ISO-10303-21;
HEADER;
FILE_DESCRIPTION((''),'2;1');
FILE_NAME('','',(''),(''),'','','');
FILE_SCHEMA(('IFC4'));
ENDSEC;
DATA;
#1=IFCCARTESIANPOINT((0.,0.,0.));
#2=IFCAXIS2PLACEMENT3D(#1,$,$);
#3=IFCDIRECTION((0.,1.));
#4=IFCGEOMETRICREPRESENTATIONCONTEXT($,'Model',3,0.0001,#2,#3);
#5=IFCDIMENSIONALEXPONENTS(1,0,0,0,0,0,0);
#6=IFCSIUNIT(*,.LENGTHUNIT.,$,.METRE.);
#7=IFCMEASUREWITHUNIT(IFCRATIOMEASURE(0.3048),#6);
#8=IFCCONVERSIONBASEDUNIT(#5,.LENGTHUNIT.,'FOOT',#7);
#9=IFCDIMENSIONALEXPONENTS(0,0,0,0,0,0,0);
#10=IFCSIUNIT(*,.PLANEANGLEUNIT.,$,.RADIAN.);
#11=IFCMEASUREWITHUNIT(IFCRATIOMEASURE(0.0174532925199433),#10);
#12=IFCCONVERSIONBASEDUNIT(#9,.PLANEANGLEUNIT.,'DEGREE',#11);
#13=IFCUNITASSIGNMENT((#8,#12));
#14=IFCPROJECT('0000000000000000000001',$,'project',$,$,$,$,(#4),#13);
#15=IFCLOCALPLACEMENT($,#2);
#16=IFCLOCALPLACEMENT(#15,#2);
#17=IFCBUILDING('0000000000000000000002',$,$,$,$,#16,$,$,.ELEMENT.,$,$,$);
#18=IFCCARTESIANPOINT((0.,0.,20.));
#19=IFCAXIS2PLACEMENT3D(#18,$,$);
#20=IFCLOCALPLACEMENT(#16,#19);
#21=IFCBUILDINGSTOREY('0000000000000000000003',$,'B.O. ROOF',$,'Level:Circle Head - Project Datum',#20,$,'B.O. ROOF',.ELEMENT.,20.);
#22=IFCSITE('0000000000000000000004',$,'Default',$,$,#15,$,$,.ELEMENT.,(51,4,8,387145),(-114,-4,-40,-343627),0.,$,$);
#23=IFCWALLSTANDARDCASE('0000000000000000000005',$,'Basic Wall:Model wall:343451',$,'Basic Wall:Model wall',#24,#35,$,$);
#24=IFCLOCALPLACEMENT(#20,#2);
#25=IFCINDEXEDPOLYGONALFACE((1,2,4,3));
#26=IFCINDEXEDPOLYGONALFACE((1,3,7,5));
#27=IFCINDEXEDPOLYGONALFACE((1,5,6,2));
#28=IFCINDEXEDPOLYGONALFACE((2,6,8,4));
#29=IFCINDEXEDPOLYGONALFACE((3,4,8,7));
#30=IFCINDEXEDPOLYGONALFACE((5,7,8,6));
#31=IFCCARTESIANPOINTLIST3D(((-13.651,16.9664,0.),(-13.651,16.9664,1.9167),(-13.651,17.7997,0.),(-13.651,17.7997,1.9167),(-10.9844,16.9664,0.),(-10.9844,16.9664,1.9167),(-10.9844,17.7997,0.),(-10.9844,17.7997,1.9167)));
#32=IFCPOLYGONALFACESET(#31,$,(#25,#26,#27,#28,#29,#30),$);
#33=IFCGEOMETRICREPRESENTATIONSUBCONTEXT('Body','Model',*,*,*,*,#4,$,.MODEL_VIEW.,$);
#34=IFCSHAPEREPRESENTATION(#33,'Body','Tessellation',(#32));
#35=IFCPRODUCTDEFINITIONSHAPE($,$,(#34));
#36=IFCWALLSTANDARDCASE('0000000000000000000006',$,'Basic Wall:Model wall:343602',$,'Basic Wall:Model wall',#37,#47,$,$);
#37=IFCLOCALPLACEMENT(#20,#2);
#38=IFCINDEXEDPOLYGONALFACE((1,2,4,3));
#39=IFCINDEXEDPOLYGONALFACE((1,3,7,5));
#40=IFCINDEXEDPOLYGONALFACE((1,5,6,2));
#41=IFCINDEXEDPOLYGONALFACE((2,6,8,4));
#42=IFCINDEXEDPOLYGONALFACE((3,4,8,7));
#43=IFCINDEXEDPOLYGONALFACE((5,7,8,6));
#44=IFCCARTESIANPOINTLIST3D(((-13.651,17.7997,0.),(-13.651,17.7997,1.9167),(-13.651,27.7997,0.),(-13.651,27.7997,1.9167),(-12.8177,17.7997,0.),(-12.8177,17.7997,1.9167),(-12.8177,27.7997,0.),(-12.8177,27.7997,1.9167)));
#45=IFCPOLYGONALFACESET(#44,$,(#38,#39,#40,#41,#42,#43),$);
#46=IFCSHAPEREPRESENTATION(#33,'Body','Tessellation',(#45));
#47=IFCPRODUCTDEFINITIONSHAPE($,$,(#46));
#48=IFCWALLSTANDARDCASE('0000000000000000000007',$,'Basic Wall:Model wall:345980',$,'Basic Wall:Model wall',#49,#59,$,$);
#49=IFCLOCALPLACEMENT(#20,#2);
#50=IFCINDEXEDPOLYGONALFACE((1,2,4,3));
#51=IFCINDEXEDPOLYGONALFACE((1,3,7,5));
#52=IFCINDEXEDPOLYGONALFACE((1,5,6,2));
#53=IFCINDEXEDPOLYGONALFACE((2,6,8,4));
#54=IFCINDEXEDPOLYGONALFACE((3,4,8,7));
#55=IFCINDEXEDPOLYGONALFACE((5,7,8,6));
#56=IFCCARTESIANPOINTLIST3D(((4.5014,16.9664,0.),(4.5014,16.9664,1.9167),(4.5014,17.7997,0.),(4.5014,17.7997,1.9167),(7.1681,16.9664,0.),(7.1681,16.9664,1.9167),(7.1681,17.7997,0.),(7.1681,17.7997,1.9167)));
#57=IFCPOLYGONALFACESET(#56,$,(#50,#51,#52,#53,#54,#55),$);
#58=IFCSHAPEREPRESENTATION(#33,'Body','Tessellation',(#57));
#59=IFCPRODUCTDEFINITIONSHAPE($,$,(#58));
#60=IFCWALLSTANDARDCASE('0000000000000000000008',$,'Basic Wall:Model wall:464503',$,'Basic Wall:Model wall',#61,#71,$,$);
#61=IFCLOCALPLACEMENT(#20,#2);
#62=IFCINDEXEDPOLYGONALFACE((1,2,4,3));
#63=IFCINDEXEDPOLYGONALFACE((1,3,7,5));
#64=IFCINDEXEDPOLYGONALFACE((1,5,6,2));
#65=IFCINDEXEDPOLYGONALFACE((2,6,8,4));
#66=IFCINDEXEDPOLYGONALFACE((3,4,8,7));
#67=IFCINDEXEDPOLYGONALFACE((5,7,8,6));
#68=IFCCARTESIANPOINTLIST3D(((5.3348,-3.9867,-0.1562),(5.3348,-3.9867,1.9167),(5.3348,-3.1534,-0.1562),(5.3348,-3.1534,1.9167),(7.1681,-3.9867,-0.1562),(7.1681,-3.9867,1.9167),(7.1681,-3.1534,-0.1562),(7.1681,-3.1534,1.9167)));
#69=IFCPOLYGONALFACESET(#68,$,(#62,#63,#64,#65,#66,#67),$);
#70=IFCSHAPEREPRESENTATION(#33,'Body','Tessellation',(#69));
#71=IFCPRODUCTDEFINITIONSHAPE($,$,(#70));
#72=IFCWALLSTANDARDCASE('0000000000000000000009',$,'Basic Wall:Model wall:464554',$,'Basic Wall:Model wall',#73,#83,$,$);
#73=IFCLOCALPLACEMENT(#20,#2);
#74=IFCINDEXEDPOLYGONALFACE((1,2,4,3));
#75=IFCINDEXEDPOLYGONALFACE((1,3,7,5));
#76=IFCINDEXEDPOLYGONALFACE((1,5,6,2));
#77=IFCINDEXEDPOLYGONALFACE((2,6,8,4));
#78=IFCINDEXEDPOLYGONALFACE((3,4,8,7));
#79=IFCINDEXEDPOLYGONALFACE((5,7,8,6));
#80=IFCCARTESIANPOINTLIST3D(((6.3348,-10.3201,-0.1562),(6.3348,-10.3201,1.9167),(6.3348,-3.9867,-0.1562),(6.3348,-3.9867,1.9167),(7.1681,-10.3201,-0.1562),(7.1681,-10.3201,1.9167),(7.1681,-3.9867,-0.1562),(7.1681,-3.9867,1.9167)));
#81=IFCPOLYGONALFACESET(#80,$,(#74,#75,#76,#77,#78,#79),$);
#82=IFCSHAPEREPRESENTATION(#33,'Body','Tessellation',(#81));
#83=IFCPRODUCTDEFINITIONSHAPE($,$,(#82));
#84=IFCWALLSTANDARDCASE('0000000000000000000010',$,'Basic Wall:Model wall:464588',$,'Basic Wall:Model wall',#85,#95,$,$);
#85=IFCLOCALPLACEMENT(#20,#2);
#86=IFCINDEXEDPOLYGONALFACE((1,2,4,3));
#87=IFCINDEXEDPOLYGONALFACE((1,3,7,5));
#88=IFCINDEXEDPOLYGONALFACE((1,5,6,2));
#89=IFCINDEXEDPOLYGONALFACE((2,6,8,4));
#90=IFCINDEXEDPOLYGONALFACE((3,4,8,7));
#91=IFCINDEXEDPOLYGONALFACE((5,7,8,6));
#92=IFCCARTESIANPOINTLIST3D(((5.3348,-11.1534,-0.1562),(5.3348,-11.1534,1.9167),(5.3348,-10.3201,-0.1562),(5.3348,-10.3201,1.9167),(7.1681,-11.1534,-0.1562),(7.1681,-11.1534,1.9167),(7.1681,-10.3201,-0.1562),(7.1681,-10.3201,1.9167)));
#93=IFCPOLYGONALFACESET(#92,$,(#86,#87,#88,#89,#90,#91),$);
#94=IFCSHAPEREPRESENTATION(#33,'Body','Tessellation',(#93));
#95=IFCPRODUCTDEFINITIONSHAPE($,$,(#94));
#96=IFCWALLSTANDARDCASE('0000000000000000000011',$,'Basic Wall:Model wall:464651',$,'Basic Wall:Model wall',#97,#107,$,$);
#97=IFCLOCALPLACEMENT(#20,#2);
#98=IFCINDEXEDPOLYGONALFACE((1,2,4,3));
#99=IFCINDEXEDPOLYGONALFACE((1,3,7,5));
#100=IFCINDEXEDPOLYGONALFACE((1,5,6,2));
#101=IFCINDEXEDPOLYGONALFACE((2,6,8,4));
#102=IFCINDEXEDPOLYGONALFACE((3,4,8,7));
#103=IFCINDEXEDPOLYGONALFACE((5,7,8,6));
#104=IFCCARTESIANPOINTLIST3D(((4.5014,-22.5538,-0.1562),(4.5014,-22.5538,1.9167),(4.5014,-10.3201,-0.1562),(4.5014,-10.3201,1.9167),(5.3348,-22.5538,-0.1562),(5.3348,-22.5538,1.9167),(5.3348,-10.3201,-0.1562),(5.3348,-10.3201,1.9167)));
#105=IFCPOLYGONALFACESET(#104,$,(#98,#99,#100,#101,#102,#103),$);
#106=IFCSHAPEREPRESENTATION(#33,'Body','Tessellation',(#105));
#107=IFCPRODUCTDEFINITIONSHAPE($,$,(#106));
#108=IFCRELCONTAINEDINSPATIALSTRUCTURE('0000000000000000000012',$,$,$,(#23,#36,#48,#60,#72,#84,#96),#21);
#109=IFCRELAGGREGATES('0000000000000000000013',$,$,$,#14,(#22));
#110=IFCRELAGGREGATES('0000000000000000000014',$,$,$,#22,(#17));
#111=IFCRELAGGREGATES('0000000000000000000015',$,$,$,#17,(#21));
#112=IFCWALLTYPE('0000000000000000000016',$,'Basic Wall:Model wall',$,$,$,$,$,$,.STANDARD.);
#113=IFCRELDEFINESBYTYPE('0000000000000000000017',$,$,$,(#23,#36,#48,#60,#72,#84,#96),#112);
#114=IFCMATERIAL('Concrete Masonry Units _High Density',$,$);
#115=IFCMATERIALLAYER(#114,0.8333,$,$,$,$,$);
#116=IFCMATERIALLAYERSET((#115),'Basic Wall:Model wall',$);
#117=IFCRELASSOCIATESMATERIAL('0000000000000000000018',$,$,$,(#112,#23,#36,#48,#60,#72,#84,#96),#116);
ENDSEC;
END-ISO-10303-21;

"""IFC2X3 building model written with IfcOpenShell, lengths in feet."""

from ifc_helpers import new_model, entity, si_unit, converted_unit, direction, frame, frame_2d, origin, place, context, subcontext, project, spatial, rectangle, extrude, material, layer, layer_set, layer_usage, type_object, element, save


model = new_model("IFC2X3")

# Units and contexts
model_context = context("Model", 3, precision=0.0001, world=origin(), true_north=direction((0.0, 1.0)))
body_context = subcontext(model_context, "Body", "Model", "MODEL_VIEW")
ifc_project = project(units=[converted_unit("LENGTHUNIT", "FOOT", entity("IfcRatioMeasure", 0.3048), si_unit("LENGTHUNIT", "METRE"), dimensions=[1, 0, 0, 0, 0, 0, 0]), converted_unit("PLANEANGLEUNIT", "DEGREE", entity("IfcRatioMeasure", 0.0174532925199433), si_unit("PLANEANGLEUNIT", "RADIAN"), dimensions=[0, 0, 0, 0, 0, 0, 0])], contexts=[model_context])

# Site, building, storey
site_placement = place(None, origin())
site = spatial("IfcSite", under=ifc_project, at=site_placement, Name="Default", CompositionType="ELEMENT", RefLatitude=(51, 4, 8, 387145), RefLongitude=(-114, -4, -40, -343627), RefElevation=0.0)
building_placement = place(site_placement, origin())
building = spatial("IfcBuilding", under=site, at=building_placement, CompositionType="ELEMENT")
storey_placement = place(building_placement, frame((0.0, 0.0, 20.0)))
storey = spatial("IfcBuildingStorey", under=building, at=storey_placement, Name="B.O. ROOF", ObjectType="Level:Circle Head - Project Datum", LongName="B.O. ROOF", CompositionType="ELEMENT", Elevation=20.0)

# Walls
ifc_material_1 = material(Name="Concrete Masonry Units _High Density")
ifc_layer_1 = layer(ifc_material_1, 0.8333)
ifc_layer_set_1 = layer_set([ifc_layer_1], Name="Basic Wall:Model wall")
wall_type = type_object("IfcWallType", Name="Basic Wall:Model wall", PredefinedType="STANDARD", material=ifc_layer_set_1)
ifc_layer_usage_1 = layer_usage(ifc_layer_set_1, "AXIS2", "NEGATIVE", 0.4167)
wall_1_placement = place(storey_placement, frame((-10.9844, 17.383, 0.0), z_axis=(0.0, 0.0, 1.0), x_axis=(-1.0, 0.0, 0.0)))
element("IfcWallStandardCase", 1, at=wall_1_placement, inside=storey, type_object=wall_type, material=ifc_layer_usage_1, Name="Basic Wall:Model wall:343451", ObjectType="Basic Wall:Model wall", context=body_context, shape_type="SweptSolid", body=[
    extrude(rectangle(XDim=2.6667, YDim=0.8333, at=frame_2d((1.3333, 0.0), x_axis=(-1.0, 0.0))), origin(), (0.0, 0.0, 1.0), 1.9167),
])
ifc_layer_usage_2 = layer_usage(ifc_layer_set_1, "AXIS2", "NEGATIVE", 0.4167)
wall_2_placement = place(storey_placement, frame((-13.2344, 17.7997, 0.0), z_axis=(0.0, 0.0, 1.0), x_axis=(0.0, 1.0, 0.0)))
element("IfcWallStandardCase", 2, at=wall_2_placement, inside=storey, type_object=wall_type, material=ifc_layer_usage_2, Name="Basic Wall:Model wall:343602", ObjectType="Basic Wall:Model wall", context=body_context, shape_type="SweptSolid", body=[
    extrude(rectangle(XDim=10.0, YDim=0.8333, at=frame_2d((5.0, 0.0), x_axis=(-1.0, 0.0))), origin(), (0.0, 0.0, 1.0), 1.9167),
])
ifc_layer_usage_3 = layer_usage(ifc_layer_set_1, "AXIS2", "NEGATIVE", 0.4167)
wall_3_placement = place(storey_placement, frame((4.5014, 17.383, 0.0)))
element("IfcWallStandardCase", 3, at=wall_3_placement, inside=storey, type_object=wall_type, material=ifc_layer_usage_3, Name="Basic Wall:Model wall:345980", ObjectType="Basic Wall:Model wall", context=body_context, shape_type="SweptSolid", body=[
    extrude(rectangle(XDim=2.6667, YDim=0.8333, at=frame_2d((1.3333, 0.0), x_axis=(-1.0, 0.0))), origin(), (0.0, 0.0, 1.0), 1.9167),
])
ifc_layer_usage_4 = layer_usage(ifc_layer_set_1, "AXIS2", "NEGATIVE", 0.4167)
wall_4_placement = place(storey_placement, frame((5.3348, -3.5701, -0.1562)))
element("IfcWallStandardCase", 4, at=wall_4_placement, inside=storey, type_object=wall_type, material=ifc_layer_usage_4, Name="Basic Wall:Model wall:464503", ObjectType="Basic Wall:Model wall", context=body_context, shape_type="SweptSolid", body=[
    extrude(rectangle(XDim=1.8333, YDim=0.8333, at=frame_2d((0.9167, 0.0), x_axis=(-1.0, 0.0))), origin(), (0.0, 0.0, 1.0), 2.0728),
])
ifc_layer_usage_5 = layer_usage(ifc_layer_set_1, "AXIS2", "NEGATIVE", 0.4167)
wall_5_placement = place(storey_placement, frame((6.7514, -3.9867, -0.1562), z_axis=(0.0, 0.0, 1.0), x_axis=(0.0, -1.0, 0.0)))
element("IfcWallStandardCase", 5, at=wall_5_placement, inside=storey, type_object=wall_type, material=ifc_layer_usage_5, Name="Basic Wall:Model wall:464554", ObjectType="Basic Wall:Model wall", context=body_context, shape_type="SweptSolid", body=[
    extrude(rectangle(XDim=6.3333, YDim=0.8333, at=frame_2d((3.1667, 0.0), x_axis=(-1.0, 0.0))), origin(), (0.0, 0.0, 1.0), 2.0728),
])
ifc_layer_usage_6 = layer_usage(ifc_layer_set_1, "AXIS2", "NEGATIVE", 0.4167)
wall_6_placement = place(storey_placement, frame((7.1681, -10.7367, -0.1562), z_axis=(0.0, 0.0, 1.0), x_axis=(-1.0, 0.0, 0.0)))
element("IfcWallStandardCase", 6, at=wall_6_placement, inside=storey, type_object=wall_type, material=ifc_layer_usage_6, Name="Basic Wall:Model wall:464588", ObjectType="Basic Wall:Model wall", context=body_context, shape_type="SweptSolid", body=[
    extrude(rectangle(XDim=1.8333, YDim=0.8333, at=frame_2d((0.9167, 0.0), x_axis=(-1.0, 0.0))), origin(), (0.0, 0.0, 1.0), 2.0728),
])
ifc_layer_usage_7 = layer_usage(ifc_layer_set_1, "AXIS2", "NEGATIVE", 0.4167)
wall_7_placement = place(storey_placement, frame((4.9181, -10.3201, -0.1562), z_axis=(0.0, 0.0, 1.0), x_axis=(0.0, -1.0, 0.0)))
element("IfcWallStandardCase", 7, at=wall_7_placement, inside=storey, type_object=wall_type, material=ifc_layer_usage_7, Name="Basic Wall:Model wall:464651", ObjectType="Basic Wall:Model wall", context=body_context, shape_type="SweptSolid", body=[
    extrude(rectangle(XDim=12.2337, YDim=0.8333, at=frame_2d((6.1169, 0.0), x_axis=(-1.0, 0.0))), origin(), (0.0, 0.0, 1.0), 2.0728),
])

save(model, "model.ifc")
